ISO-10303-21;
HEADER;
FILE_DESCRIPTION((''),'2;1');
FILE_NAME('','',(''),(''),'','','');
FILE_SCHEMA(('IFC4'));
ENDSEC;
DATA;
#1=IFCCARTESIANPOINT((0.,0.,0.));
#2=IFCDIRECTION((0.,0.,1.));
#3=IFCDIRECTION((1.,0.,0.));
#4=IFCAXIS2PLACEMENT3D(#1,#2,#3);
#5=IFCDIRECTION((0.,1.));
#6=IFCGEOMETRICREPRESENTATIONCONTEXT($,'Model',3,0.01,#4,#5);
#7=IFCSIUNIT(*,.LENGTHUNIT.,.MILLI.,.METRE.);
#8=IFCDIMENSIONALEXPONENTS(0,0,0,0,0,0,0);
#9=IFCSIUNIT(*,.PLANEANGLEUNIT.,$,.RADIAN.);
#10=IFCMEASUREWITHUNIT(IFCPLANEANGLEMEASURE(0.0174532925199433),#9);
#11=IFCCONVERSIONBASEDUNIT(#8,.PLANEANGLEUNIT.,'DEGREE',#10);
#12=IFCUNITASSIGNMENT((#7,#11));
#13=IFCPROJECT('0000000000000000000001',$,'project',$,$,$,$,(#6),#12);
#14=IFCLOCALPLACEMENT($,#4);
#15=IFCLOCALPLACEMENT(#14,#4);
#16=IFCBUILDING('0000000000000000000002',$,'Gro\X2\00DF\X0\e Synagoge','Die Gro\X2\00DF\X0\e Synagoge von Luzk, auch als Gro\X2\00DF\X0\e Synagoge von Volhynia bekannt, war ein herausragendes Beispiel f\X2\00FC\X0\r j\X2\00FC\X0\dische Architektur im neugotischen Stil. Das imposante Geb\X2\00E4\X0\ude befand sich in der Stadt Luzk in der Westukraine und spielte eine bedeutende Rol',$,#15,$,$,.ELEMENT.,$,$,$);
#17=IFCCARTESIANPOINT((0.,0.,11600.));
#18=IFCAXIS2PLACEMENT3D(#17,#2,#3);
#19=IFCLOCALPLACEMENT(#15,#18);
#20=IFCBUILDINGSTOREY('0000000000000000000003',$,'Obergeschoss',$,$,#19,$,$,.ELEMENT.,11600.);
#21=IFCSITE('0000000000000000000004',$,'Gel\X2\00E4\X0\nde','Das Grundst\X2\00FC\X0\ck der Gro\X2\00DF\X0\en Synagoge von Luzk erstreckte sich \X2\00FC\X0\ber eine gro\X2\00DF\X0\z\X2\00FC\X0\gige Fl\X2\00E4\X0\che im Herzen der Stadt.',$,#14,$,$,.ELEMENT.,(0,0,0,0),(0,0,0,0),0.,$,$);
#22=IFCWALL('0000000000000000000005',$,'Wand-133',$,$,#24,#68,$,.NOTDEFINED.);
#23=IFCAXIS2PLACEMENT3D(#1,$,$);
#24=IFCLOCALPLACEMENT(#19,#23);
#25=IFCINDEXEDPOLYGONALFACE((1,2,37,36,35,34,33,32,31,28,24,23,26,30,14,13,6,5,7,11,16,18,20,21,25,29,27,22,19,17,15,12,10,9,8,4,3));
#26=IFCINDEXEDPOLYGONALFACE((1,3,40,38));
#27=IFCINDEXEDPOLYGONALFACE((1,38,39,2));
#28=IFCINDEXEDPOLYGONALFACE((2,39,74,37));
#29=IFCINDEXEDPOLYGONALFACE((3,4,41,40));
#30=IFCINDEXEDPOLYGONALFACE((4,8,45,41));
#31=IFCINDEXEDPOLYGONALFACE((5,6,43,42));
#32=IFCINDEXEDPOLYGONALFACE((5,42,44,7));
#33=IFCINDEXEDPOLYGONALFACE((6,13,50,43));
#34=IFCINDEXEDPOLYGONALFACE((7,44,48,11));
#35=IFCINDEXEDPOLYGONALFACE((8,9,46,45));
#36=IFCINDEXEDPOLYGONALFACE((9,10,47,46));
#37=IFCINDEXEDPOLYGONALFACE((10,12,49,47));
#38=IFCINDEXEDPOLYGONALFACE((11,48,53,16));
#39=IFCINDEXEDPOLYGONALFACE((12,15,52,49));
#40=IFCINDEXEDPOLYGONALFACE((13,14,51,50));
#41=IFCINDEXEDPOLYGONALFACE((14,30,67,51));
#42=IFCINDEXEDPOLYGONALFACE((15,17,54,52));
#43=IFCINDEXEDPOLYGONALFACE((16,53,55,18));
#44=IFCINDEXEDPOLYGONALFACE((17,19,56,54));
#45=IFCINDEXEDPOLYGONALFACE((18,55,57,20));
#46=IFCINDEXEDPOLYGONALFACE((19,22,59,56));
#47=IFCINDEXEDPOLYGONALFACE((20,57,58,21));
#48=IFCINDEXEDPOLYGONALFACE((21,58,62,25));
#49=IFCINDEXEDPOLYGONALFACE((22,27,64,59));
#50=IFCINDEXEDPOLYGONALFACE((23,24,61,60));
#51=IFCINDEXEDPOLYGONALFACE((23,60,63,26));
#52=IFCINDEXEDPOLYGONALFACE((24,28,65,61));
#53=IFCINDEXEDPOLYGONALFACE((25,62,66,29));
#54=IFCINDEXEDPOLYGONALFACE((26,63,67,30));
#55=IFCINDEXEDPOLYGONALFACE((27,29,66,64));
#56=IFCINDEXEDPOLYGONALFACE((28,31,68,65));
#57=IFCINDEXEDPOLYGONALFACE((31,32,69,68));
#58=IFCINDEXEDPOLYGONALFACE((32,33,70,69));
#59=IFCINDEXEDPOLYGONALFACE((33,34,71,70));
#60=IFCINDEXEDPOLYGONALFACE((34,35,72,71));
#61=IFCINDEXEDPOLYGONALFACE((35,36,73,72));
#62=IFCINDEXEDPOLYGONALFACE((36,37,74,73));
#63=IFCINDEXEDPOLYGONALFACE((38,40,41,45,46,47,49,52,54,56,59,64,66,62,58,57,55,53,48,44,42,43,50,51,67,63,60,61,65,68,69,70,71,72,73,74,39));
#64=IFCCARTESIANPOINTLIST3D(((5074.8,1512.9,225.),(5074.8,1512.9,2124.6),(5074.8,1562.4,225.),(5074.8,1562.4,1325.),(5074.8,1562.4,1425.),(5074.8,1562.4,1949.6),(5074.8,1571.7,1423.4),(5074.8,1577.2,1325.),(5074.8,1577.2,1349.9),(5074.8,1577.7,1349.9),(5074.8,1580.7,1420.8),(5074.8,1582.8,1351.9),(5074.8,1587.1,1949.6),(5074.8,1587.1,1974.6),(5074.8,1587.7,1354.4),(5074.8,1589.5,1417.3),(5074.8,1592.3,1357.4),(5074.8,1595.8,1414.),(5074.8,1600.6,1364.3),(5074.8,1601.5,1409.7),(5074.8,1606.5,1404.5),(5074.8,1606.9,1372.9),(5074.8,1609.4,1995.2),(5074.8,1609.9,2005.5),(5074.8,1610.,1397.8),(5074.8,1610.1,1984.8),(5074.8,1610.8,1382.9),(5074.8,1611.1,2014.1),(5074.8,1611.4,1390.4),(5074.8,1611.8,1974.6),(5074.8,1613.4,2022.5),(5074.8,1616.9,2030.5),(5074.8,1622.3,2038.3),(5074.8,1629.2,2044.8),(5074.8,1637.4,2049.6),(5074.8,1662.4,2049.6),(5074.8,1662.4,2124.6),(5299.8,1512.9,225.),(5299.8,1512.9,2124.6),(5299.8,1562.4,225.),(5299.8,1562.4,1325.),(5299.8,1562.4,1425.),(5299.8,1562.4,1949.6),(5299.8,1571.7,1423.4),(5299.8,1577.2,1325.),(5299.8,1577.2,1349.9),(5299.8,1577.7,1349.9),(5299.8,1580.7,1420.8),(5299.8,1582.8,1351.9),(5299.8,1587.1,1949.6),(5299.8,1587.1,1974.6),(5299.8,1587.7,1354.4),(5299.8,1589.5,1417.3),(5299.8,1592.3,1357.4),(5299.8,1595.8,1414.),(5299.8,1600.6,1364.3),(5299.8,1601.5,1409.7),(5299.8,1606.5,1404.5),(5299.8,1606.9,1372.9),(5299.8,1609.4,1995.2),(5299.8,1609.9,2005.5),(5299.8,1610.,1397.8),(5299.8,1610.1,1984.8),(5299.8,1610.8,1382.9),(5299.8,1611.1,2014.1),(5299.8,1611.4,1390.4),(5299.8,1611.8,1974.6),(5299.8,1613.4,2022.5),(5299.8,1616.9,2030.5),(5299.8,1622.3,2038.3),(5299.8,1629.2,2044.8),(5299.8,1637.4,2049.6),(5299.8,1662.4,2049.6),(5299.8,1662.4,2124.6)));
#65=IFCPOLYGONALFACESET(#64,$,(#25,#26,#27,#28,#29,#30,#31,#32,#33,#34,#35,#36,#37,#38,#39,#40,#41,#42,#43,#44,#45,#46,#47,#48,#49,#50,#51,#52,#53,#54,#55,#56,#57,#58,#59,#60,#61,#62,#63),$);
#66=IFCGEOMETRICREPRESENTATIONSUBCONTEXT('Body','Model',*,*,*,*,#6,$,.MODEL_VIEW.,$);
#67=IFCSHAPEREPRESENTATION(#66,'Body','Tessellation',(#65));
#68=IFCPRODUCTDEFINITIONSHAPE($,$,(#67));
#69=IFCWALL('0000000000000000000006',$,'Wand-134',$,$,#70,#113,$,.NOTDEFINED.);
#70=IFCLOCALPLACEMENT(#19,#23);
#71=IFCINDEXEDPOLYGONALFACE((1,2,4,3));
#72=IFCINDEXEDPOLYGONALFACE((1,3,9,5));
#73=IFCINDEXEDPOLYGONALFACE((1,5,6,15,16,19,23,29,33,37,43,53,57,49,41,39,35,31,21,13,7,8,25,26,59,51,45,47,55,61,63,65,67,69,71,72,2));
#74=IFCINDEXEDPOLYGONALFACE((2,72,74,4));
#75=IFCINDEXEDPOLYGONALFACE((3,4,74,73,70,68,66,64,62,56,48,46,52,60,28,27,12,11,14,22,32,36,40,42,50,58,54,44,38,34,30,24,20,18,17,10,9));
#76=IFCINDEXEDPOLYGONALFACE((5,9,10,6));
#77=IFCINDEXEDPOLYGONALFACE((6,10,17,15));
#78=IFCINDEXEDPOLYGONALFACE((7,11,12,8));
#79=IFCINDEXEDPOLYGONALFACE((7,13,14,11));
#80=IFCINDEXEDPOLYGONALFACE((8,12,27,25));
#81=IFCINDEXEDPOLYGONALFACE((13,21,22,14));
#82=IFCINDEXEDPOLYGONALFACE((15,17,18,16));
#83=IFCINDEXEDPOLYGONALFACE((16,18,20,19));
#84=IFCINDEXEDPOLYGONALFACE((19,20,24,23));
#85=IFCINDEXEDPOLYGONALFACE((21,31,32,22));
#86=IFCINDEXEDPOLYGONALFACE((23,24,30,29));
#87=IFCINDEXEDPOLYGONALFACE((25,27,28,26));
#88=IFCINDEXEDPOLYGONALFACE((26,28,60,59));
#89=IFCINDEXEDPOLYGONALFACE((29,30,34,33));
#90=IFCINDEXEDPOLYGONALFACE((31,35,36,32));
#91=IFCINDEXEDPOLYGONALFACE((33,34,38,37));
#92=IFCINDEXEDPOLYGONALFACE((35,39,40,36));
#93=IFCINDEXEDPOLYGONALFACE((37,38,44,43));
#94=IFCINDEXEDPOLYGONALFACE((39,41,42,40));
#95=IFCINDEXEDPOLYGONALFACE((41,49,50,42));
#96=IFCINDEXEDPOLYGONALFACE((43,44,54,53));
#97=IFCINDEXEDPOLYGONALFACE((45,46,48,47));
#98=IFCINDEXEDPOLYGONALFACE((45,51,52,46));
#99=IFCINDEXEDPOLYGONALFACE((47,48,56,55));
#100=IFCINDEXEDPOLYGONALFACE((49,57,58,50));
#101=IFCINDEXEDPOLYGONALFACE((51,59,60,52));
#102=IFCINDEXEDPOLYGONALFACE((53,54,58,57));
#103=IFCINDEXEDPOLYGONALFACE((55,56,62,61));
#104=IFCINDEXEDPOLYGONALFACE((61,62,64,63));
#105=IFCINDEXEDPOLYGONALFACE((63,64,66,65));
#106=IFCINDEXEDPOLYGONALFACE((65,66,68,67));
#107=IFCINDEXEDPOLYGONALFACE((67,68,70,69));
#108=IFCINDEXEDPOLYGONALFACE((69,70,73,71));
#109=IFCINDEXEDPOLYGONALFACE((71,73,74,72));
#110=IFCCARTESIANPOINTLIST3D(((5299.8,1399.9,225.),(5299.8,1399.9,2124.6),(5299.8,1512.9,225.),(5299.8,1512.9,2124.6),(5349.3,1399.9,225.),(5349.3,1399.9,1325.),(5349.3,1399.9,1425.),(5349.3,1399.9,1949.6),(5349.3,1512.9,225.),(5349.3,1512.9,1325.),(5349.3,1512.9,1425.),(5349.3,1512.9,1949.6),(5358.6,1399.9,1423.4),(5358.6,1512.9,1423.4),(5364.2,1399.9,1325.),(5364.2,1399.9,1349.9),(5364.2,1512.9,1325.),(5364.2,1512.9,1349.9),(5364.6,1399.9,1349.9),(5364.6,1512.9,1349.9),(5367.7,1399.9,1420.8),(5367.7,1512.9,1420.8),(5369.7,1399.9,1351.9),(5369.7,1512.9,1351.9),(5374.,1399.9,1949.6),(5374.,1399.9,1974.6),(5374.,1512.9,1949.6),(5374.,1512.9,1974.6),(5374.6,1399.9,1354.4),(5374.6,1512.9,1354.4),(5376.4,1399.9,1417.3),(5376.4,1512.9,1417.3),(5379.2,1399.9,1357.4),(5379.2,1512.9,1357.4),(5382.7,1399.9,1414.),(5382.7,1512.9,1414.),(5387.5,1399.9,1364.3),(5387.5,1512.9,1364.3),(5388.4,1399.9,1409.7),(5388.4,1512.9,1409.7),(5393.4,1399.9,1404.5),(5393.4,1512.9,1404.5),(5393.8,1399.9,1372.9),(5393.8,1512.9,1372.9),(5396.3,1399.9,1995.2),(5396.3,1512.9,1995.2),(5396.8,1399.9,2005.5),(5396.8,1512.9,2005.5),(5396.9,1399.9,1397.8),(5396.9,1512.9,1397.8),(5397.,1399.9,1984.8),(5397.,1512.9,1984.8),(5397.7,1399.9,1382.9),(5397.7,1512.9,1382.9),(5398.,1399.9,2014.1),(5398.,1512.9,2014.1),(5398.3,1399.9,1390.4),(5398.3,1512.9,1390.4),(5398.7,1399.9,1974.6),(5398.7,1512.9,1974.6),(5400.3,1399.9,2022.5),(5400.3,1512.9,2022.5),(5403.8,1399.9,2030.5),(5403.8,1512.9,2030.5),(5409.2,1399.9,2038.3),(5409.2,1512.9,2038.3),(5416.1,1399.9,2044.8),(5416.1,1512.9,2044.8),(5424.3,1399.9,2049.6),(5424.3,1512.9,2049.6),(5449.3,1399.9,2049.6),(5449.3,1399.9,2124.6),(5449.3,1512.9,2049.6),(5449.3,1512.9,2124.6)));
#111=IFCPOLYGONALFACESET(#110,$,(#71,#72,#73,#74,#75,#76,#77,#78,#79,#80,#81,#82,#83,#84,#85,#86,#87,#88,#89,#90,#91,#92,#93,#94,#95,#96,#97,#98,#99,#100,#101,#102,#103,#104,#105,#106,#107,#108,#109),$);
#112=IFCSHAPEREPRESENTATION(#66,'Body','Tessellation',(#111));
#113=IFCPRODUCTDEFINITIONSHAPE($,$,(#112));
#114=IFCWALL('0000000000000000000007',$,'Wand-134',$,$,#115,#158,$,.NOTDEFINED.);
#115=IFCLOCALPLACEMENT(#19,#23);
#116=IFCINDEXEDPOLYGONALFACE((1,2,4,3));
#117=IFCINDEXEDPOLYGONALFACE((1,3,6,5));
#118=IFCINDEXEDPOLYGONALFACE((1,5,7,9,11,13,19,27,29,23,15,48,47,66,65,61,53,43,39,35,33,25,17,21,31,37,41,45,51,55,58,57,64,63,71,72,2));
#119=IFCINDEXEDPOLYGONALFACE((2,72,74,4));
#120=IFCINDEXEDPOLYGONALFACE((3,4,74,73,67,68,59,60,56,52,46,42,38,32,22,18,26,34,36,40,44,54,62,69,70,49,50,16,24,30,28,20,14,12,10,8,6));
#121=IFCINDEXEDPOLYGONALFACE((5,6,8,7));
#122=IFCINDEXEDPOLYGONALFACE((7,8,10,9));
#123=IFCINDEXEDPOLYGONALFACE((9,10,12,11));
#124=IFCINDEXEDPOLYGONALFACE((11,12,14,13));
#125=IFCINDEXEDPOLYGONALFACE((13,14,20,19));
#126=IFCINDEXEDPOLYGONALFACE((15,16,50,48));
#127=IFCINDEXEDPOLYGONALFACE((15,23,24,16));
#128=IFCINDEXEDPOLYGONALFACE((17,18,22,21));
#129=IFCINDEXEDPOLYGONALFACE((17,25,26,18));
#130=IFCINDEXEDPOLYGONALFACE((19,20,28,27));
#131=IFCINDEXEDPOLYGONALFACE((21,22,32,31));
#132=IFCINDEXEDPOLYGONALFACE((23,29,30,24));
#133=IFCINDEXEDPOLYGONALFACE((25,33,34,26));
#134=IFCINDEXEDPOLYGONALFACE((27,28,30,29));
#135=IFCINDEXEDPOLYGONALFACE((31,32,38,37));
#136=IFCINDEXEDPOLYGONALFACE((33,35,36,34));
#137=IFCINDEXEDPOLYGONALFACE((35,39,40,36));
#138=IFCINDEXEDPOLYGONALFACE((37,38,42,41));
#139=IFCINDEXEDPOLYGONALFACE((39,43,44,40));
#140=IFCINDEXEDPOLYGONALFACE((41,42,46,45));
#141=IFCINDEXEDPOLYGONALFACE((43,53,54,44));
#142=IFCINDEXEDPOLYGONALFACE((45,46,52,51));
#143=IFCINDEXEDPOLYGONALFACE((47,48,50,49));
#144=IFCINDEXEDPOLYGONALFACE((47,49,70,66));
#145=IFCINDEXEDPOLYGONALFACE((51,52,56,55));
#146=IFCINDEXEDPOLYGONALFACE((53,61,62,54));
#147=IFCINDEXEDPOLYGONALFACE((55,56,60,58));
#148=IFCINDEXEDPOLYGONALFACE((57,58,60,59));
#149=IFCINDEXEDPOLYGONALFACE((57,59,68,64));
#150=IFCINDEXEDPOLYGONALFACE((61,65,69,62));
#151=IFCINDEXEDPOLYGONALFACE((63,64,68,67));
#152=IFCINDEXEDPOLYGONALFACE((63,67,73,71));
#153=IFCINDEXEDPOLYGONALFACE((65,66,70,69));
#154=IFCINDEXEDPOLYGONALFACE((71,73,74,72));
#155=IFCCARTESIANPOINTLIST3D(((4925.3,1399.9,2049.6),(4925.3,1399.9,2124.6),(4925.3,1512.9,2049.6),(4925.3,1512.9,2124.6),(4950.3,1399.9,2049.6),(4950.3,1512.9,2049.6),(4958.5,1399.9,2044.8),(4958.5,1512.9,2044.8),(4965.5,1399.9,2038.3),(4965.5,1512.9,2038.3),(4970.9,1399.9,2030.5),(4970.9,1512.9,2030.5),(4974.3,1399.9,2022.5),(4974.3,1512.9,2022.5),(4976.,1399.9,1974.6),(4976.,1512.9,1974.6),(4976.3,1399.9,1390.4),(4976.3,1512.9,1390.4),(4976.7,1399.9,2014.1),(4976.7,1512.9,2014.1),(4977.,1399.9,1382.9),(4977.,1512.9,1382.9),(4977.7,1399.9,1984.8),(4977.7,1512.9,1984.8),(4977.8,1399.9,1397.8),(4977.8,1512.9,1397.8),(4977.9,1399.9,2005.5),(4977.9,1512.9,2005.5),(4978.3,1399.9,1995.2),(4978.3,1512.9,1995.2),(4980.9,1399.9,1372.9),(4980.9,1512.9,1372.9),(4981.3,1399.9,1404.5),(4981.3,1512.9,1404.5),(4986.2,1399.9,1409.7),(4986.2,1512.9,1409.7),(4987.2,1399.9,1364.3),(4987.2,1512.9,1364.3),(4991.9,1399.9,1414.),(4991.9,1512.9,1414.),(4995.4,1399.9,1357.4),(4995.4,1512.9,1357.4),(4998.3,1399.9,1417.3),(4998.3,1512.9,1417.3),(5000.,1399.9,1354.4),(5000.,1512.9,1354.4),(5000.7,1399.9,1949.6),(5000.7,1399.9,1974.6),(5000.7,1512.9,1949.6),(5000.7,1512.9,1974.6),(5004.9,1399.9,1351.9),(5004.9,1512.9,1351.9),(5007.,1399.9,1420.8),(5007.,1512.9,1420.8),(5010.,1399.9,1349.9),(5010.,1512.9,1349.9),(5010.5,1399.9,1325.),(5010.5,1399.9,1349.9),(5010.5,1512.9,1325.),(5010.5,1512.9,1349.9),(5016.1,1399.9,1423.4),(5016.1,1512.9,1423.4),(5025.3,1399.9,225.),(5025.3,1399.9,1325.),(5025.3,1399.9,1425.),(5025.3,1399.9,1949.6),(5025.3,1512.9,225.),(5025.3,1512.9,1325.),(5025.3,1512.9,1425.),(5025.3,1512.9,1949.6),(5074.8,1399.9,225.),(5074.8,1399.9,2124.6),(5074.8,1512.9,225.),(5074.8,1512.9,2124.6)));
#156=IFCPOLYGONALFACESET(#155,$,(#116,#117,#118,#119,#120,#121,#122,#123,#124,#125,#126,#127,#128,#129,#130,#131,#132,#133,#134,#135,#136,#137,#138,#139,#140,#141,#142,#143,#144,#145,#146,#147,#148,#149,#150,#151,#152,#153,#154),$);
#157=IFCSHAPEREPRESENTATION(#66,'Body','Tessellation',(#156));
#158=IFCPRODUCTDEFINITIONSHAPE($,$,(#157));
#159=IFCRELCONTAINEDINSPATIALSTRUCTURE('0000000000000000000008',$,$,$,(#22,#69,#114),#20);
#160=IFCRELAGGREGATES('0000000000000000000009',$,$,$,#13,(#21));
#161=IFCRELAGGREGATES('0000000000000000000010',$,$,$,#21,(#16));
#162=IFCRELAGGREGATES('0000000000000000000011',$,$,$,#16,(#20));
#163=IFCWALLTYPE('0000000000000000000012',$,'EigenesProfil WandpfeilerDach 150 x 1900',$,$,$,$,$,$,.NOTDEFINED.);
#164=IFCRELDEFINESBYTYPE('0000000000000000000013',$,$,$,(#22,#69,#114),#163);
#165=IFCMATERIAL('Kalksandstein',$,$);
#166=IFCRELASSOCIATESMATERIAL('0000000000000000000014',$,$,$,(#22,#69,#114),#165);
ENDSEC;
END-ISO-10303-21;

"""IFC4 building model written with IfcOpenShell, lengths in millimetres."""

from ifc_helpers import new_model, entity, si_unit, converted_unit, direction, frame, origin_with_axes, place, context, subcontext, project, spatial, line, arc, indexed_curve, outline, extrude, material, material_profile, profile_set, type_object, element, save


model = new_model("IFC4")

# Units and contexts
model_context = context("Model", 3, precision=0.01, world=origin_with_axes(), true_north=direction((0.0, 1.0)))
body_context = subcontext(model_context, "Body", "Model", "MODEL_VIEW")
ifc_project = project(units=[si_unit("LENGTHUNIT", "METRE", prefix="MILLI"), converted_unit("PLANEANGLEUNIT", "DEGREE", entity("IfcPlaneAngleMeasure", 0.0174532925199433), si_unit("PLANEANGLEUNIT", "RADIAN"), dimensions=[0, 0, 0, 0, 0, 0, 0])], contexts=[model_context])

# Site, building, storey
site_placement = place(None, origin_with_axes())
site = spatial("IfcSite", under=ifc_project, at=site_placement, Name="Gelände", Description="Das Grundstück der Großen Synagoge von Luzk erstreckte sich über eine großzügige Fläche im Herzen der Stadt.", CompositionType="ELEMENT", RefLatitude=(0, 0, 0, 0), RefLongitude=(0, 0, 0, 0), RefElevation=0.0)
building_placement = place(site_placement, origin_with_axes())
building = spatial("IfcBuilding", under=site, at=building_placement, Name="Große Synagoge", Description="Die Große Synagoge von Luzk, auch als Große Synagoge von Volhynia bekannt, war ein herausragendes Beispiel für jüdische Architektur im neugotischen Stil. Das imposante Gebäude befand sich in der Stadt Luzk in der Westukraine und spielte eine bedeutende Rol", CompositionType="ELEMENT")
storey_placement = place(building_placement, frame((0.0, 0.0, 11600.0), z_axis=(0.0, 0.0, 1.0), x_axis=(1.0, 0.0, 0.0)))
storey = spatial("IfcBuildingStorey", under=building, at=storey_placement, Name="Obergeschoss", CompositionType="ELEMENT", Elevation=11600.0)

# Walls
ifc_material_1 = material(Name="Kalksandstein")
ifc_material_profile = material_profile(ifc_material_1, outline(indexed_curve([(74.2, 1749.6), (98.9, 1749.6), (96.7, 1765.0), (97.0, 1780.5), (99.2, 1793.4), (103.9, 1805.5), (112.6, 1816.7), (124.5, 1824.6), (149.5, 1824.6), (149.5, 1899.6), (0.0, 1899.6), (0.0, 0.0), (49.5, 0.0), (49.5, 1100.0), (64.3, 1100.0), (64.3, 1124.9), (64.8, 1124.9), (72.4, 1128.1), (79.4, 1132.4), (91.1, 1143.4), (97.9, 1157.9), (98.0, 1169.2), (93.5, 1179.5), (85.8, 1187.0), (76.6, 1192.3), (63.3, 1197.2), (49.5, 1200.0), (49.5, 1724.6), (74.2, 1724.6)], segments=[line(1, 2), arc(2, 3, 4), arc(4, 5, 6), arc(6, 7, 8), line(8, 9, 10, 11, 12, 13, 14, 15, 16, 17), arc(17, 18, 19), arc(19, 20, 21), arc(21, 22, 23), arc(23, 24, 25), arc(25, 26, 27), line(27, 28, 29, 1)])), Name="Kalksandstein")
ifc_profile_set = profile_set([ifc_material_profile], Name="EigenesProfil WandpfeilerDach")
wall_type_1 = type_object("IfcWallType", Name="EigenesProfil WandpfeilerDach 150 x 1900", PredefinedType="NOTDEFINED")
wall_1_placement = place(storey_placement, frame((5074.8, 1512.9, 225.0), z_axis=(0.0, 0.0, 1.0), x_axis=(1.0, 0.0, 0.0)))
element("IfcWall", 1, at=wall_1_placement, inside=storey, type_object=wall_type_1, material=ifc_profile_set, Name="Wand-133", PredefinedType="NOTDEFINED", context=body_context, shape_type="SweptSolid", body=[
    extrude(outline(indexed_curve([(74.2, 1749.6), (98.9, 1749.6), (96.7, 1765.0), (97.0, 1780.5), (99.2, 1793.4), (103.9, 1805.5), (112.6, 1816.7), (124.5, 1824.6), (149.5, 1824.6), (149.5, 1899.6), (0.0, 1899.6), (0.0, 0.0), (49.5, 0.0), (49.5, 1100.0), (64.3, 1100.0), (64.3, 1124.9), (64.8, 1124.9), (72.4, 1128.1), (79.4, 1132.4), (91.1, 1143.4), (97.9, 1157.9), (98.0, 1169.2), (93.5, 1179.5), (85.8, 1187.0), (76.6, 1192.3), (63.3, 1197.2), (49.5, 1200.0), (49.5, 1724.6), (74.2, 1724.6)], segments=[line(1, 2), arc(2, 3, 4), arc(4, 5, 6), arc(6, 7, 8), line(8, 9, 10, 11, 12, 13, 14, 15, 16, 17), arc(17, 18, 19), arc(19, 20, 21), arc(21, 22, 23), arc(23, 24, 25), arc(25, 26, 27), line(27, 28, 29, 1)])), frame((0.0, 0.0, 0.0), z_axis=(1.0, 0.0, 0.0), x_axis=(0.0, 1.0, 0.0)), (0.0, 0.0, 1.0), 225.0),
])
wall_2_placement = place(storey_placement, frame((5299.8, 1512.9, 225.0), z_axis=(0.0, 0.0, 1.0), x_axis=(0.0, -1.0, 0.0)))
element("IfcWall", 2, at=wall_2_placement, inside=storey, type_object=wall_type_1, material=ifc_profile_set, Name="Wand-134", PredefinedType="NOTDEFINED", context=body_context, shape_type="SweptSolid", body=[
    extrude(outline(indexed_curve([(74.2, 1749.6), (98.9, 1749.6), (96.7, 1765.0), (97.0, 1780.5), (99.2, 1793.4), (103.9, 1805.5), (112.6, 1816.7), (124.5, 1824.6), (149.5, 1824.6), (149.5, 1899.6), (0.0, 1899.6), (0.0, 0.0), (49.5, 0.0), (49.5, 1100.0), (64.3, 1100.0), (64.3, 1124.9), (64.8, 1124.9), (72.4, 1128.1), (79.4, 1132.4), (91.1, 1143.4), (97.9, 1157.9), (98.0, 1169.2), (93.5, 1179.5), (85.8, 1187.0), (76.6, 1192.3), (63.3, 1197.2), (49.5, 1200.0), (49.5, 1724.6), (74.2, 1724.6)], segments=[line(1, 2), arc(2, 3, 4), arc(4, 5, 6), arc(6, 7, 8), line(8, 9, 10, 11, 12, 13, 14, 15, 16, 17), arc(17, 18, 19), arc(19, 20, 21), arc(21, 22, 23), arc(23, 24, 25), arc(25, 26, 27), line(27, 28, 29, 1)])), frame((0.0, 0.0, 0.0), z_axis=(1.0, 0.0, 0.0), x_axis=(0.0, 1.0, 0.0)), (0.0, 0.0, 1.0), 113.0),
])
wall_3_placement = place(storey_placement, frame((5074.8, 1512.9, 225.0), z_axis=(0.0, 0.0, 1.0), x_axis=(0.0, -1.0, 0.0)))
element("IfcWall", 3, at=wall_3_placement, inside=storey, type_object=wall_type_1, material=ifc_profile_set, Name="Wand-134", PredefinedType="NOTDEFINED", context=body_context, shape_type="SweptSolid", body=[
    extrude(outline(indexed_curve([(74.2, 1749.6), (98.9, 1749.6), (96.7, 1765.0), (97.0, 1780.5), (99.2, 1793.4), (103.9, 1805.5), (112.6, 1816.7), (124.5, 1824.6), (149.5, 1824.6), (149.5, 1899.6), (0.0, 1899.6), (0.0, 0.0), (49.5, 0.0), (49.5, 1100.0), (64.3, 1100.0), (64.3, 1124.9), (64.8, 1124.9), (72.4, 1128.1), (79.4, 1132.4), (91.1, 1143.4), (97.9, 1157.9), (98.0, 1169.2), (93.5, 1179.5), (85.8, 1187.0), (76.6, 1192.3), (63.3, 1197.2), (49.5, 1200.0), (49.5, 1724.6), (74.2, 1724.6)], segments=[line(1, 2), arc(2, 3, 4), arc(4, 5, 6), arc(6, 7, 8), line(8, 9, 10, 11, 12, 13, 14, 15, 16, 17), arc(17, 18, 19), arc(19, 20, 21), arc(21, 22, 23), arc(23, 24, 25), arc(25, 26, 27), line(27, 28, 29, 1)])), frame((0.0, 0.0, 0.0), z_axis=(-1.0, 0.0, 0.0), x_axis=(0.0, -1.0, 0.0)), (0.0, 0.0, -1.0), 113.0),
])

save(model, "model.ifc")
